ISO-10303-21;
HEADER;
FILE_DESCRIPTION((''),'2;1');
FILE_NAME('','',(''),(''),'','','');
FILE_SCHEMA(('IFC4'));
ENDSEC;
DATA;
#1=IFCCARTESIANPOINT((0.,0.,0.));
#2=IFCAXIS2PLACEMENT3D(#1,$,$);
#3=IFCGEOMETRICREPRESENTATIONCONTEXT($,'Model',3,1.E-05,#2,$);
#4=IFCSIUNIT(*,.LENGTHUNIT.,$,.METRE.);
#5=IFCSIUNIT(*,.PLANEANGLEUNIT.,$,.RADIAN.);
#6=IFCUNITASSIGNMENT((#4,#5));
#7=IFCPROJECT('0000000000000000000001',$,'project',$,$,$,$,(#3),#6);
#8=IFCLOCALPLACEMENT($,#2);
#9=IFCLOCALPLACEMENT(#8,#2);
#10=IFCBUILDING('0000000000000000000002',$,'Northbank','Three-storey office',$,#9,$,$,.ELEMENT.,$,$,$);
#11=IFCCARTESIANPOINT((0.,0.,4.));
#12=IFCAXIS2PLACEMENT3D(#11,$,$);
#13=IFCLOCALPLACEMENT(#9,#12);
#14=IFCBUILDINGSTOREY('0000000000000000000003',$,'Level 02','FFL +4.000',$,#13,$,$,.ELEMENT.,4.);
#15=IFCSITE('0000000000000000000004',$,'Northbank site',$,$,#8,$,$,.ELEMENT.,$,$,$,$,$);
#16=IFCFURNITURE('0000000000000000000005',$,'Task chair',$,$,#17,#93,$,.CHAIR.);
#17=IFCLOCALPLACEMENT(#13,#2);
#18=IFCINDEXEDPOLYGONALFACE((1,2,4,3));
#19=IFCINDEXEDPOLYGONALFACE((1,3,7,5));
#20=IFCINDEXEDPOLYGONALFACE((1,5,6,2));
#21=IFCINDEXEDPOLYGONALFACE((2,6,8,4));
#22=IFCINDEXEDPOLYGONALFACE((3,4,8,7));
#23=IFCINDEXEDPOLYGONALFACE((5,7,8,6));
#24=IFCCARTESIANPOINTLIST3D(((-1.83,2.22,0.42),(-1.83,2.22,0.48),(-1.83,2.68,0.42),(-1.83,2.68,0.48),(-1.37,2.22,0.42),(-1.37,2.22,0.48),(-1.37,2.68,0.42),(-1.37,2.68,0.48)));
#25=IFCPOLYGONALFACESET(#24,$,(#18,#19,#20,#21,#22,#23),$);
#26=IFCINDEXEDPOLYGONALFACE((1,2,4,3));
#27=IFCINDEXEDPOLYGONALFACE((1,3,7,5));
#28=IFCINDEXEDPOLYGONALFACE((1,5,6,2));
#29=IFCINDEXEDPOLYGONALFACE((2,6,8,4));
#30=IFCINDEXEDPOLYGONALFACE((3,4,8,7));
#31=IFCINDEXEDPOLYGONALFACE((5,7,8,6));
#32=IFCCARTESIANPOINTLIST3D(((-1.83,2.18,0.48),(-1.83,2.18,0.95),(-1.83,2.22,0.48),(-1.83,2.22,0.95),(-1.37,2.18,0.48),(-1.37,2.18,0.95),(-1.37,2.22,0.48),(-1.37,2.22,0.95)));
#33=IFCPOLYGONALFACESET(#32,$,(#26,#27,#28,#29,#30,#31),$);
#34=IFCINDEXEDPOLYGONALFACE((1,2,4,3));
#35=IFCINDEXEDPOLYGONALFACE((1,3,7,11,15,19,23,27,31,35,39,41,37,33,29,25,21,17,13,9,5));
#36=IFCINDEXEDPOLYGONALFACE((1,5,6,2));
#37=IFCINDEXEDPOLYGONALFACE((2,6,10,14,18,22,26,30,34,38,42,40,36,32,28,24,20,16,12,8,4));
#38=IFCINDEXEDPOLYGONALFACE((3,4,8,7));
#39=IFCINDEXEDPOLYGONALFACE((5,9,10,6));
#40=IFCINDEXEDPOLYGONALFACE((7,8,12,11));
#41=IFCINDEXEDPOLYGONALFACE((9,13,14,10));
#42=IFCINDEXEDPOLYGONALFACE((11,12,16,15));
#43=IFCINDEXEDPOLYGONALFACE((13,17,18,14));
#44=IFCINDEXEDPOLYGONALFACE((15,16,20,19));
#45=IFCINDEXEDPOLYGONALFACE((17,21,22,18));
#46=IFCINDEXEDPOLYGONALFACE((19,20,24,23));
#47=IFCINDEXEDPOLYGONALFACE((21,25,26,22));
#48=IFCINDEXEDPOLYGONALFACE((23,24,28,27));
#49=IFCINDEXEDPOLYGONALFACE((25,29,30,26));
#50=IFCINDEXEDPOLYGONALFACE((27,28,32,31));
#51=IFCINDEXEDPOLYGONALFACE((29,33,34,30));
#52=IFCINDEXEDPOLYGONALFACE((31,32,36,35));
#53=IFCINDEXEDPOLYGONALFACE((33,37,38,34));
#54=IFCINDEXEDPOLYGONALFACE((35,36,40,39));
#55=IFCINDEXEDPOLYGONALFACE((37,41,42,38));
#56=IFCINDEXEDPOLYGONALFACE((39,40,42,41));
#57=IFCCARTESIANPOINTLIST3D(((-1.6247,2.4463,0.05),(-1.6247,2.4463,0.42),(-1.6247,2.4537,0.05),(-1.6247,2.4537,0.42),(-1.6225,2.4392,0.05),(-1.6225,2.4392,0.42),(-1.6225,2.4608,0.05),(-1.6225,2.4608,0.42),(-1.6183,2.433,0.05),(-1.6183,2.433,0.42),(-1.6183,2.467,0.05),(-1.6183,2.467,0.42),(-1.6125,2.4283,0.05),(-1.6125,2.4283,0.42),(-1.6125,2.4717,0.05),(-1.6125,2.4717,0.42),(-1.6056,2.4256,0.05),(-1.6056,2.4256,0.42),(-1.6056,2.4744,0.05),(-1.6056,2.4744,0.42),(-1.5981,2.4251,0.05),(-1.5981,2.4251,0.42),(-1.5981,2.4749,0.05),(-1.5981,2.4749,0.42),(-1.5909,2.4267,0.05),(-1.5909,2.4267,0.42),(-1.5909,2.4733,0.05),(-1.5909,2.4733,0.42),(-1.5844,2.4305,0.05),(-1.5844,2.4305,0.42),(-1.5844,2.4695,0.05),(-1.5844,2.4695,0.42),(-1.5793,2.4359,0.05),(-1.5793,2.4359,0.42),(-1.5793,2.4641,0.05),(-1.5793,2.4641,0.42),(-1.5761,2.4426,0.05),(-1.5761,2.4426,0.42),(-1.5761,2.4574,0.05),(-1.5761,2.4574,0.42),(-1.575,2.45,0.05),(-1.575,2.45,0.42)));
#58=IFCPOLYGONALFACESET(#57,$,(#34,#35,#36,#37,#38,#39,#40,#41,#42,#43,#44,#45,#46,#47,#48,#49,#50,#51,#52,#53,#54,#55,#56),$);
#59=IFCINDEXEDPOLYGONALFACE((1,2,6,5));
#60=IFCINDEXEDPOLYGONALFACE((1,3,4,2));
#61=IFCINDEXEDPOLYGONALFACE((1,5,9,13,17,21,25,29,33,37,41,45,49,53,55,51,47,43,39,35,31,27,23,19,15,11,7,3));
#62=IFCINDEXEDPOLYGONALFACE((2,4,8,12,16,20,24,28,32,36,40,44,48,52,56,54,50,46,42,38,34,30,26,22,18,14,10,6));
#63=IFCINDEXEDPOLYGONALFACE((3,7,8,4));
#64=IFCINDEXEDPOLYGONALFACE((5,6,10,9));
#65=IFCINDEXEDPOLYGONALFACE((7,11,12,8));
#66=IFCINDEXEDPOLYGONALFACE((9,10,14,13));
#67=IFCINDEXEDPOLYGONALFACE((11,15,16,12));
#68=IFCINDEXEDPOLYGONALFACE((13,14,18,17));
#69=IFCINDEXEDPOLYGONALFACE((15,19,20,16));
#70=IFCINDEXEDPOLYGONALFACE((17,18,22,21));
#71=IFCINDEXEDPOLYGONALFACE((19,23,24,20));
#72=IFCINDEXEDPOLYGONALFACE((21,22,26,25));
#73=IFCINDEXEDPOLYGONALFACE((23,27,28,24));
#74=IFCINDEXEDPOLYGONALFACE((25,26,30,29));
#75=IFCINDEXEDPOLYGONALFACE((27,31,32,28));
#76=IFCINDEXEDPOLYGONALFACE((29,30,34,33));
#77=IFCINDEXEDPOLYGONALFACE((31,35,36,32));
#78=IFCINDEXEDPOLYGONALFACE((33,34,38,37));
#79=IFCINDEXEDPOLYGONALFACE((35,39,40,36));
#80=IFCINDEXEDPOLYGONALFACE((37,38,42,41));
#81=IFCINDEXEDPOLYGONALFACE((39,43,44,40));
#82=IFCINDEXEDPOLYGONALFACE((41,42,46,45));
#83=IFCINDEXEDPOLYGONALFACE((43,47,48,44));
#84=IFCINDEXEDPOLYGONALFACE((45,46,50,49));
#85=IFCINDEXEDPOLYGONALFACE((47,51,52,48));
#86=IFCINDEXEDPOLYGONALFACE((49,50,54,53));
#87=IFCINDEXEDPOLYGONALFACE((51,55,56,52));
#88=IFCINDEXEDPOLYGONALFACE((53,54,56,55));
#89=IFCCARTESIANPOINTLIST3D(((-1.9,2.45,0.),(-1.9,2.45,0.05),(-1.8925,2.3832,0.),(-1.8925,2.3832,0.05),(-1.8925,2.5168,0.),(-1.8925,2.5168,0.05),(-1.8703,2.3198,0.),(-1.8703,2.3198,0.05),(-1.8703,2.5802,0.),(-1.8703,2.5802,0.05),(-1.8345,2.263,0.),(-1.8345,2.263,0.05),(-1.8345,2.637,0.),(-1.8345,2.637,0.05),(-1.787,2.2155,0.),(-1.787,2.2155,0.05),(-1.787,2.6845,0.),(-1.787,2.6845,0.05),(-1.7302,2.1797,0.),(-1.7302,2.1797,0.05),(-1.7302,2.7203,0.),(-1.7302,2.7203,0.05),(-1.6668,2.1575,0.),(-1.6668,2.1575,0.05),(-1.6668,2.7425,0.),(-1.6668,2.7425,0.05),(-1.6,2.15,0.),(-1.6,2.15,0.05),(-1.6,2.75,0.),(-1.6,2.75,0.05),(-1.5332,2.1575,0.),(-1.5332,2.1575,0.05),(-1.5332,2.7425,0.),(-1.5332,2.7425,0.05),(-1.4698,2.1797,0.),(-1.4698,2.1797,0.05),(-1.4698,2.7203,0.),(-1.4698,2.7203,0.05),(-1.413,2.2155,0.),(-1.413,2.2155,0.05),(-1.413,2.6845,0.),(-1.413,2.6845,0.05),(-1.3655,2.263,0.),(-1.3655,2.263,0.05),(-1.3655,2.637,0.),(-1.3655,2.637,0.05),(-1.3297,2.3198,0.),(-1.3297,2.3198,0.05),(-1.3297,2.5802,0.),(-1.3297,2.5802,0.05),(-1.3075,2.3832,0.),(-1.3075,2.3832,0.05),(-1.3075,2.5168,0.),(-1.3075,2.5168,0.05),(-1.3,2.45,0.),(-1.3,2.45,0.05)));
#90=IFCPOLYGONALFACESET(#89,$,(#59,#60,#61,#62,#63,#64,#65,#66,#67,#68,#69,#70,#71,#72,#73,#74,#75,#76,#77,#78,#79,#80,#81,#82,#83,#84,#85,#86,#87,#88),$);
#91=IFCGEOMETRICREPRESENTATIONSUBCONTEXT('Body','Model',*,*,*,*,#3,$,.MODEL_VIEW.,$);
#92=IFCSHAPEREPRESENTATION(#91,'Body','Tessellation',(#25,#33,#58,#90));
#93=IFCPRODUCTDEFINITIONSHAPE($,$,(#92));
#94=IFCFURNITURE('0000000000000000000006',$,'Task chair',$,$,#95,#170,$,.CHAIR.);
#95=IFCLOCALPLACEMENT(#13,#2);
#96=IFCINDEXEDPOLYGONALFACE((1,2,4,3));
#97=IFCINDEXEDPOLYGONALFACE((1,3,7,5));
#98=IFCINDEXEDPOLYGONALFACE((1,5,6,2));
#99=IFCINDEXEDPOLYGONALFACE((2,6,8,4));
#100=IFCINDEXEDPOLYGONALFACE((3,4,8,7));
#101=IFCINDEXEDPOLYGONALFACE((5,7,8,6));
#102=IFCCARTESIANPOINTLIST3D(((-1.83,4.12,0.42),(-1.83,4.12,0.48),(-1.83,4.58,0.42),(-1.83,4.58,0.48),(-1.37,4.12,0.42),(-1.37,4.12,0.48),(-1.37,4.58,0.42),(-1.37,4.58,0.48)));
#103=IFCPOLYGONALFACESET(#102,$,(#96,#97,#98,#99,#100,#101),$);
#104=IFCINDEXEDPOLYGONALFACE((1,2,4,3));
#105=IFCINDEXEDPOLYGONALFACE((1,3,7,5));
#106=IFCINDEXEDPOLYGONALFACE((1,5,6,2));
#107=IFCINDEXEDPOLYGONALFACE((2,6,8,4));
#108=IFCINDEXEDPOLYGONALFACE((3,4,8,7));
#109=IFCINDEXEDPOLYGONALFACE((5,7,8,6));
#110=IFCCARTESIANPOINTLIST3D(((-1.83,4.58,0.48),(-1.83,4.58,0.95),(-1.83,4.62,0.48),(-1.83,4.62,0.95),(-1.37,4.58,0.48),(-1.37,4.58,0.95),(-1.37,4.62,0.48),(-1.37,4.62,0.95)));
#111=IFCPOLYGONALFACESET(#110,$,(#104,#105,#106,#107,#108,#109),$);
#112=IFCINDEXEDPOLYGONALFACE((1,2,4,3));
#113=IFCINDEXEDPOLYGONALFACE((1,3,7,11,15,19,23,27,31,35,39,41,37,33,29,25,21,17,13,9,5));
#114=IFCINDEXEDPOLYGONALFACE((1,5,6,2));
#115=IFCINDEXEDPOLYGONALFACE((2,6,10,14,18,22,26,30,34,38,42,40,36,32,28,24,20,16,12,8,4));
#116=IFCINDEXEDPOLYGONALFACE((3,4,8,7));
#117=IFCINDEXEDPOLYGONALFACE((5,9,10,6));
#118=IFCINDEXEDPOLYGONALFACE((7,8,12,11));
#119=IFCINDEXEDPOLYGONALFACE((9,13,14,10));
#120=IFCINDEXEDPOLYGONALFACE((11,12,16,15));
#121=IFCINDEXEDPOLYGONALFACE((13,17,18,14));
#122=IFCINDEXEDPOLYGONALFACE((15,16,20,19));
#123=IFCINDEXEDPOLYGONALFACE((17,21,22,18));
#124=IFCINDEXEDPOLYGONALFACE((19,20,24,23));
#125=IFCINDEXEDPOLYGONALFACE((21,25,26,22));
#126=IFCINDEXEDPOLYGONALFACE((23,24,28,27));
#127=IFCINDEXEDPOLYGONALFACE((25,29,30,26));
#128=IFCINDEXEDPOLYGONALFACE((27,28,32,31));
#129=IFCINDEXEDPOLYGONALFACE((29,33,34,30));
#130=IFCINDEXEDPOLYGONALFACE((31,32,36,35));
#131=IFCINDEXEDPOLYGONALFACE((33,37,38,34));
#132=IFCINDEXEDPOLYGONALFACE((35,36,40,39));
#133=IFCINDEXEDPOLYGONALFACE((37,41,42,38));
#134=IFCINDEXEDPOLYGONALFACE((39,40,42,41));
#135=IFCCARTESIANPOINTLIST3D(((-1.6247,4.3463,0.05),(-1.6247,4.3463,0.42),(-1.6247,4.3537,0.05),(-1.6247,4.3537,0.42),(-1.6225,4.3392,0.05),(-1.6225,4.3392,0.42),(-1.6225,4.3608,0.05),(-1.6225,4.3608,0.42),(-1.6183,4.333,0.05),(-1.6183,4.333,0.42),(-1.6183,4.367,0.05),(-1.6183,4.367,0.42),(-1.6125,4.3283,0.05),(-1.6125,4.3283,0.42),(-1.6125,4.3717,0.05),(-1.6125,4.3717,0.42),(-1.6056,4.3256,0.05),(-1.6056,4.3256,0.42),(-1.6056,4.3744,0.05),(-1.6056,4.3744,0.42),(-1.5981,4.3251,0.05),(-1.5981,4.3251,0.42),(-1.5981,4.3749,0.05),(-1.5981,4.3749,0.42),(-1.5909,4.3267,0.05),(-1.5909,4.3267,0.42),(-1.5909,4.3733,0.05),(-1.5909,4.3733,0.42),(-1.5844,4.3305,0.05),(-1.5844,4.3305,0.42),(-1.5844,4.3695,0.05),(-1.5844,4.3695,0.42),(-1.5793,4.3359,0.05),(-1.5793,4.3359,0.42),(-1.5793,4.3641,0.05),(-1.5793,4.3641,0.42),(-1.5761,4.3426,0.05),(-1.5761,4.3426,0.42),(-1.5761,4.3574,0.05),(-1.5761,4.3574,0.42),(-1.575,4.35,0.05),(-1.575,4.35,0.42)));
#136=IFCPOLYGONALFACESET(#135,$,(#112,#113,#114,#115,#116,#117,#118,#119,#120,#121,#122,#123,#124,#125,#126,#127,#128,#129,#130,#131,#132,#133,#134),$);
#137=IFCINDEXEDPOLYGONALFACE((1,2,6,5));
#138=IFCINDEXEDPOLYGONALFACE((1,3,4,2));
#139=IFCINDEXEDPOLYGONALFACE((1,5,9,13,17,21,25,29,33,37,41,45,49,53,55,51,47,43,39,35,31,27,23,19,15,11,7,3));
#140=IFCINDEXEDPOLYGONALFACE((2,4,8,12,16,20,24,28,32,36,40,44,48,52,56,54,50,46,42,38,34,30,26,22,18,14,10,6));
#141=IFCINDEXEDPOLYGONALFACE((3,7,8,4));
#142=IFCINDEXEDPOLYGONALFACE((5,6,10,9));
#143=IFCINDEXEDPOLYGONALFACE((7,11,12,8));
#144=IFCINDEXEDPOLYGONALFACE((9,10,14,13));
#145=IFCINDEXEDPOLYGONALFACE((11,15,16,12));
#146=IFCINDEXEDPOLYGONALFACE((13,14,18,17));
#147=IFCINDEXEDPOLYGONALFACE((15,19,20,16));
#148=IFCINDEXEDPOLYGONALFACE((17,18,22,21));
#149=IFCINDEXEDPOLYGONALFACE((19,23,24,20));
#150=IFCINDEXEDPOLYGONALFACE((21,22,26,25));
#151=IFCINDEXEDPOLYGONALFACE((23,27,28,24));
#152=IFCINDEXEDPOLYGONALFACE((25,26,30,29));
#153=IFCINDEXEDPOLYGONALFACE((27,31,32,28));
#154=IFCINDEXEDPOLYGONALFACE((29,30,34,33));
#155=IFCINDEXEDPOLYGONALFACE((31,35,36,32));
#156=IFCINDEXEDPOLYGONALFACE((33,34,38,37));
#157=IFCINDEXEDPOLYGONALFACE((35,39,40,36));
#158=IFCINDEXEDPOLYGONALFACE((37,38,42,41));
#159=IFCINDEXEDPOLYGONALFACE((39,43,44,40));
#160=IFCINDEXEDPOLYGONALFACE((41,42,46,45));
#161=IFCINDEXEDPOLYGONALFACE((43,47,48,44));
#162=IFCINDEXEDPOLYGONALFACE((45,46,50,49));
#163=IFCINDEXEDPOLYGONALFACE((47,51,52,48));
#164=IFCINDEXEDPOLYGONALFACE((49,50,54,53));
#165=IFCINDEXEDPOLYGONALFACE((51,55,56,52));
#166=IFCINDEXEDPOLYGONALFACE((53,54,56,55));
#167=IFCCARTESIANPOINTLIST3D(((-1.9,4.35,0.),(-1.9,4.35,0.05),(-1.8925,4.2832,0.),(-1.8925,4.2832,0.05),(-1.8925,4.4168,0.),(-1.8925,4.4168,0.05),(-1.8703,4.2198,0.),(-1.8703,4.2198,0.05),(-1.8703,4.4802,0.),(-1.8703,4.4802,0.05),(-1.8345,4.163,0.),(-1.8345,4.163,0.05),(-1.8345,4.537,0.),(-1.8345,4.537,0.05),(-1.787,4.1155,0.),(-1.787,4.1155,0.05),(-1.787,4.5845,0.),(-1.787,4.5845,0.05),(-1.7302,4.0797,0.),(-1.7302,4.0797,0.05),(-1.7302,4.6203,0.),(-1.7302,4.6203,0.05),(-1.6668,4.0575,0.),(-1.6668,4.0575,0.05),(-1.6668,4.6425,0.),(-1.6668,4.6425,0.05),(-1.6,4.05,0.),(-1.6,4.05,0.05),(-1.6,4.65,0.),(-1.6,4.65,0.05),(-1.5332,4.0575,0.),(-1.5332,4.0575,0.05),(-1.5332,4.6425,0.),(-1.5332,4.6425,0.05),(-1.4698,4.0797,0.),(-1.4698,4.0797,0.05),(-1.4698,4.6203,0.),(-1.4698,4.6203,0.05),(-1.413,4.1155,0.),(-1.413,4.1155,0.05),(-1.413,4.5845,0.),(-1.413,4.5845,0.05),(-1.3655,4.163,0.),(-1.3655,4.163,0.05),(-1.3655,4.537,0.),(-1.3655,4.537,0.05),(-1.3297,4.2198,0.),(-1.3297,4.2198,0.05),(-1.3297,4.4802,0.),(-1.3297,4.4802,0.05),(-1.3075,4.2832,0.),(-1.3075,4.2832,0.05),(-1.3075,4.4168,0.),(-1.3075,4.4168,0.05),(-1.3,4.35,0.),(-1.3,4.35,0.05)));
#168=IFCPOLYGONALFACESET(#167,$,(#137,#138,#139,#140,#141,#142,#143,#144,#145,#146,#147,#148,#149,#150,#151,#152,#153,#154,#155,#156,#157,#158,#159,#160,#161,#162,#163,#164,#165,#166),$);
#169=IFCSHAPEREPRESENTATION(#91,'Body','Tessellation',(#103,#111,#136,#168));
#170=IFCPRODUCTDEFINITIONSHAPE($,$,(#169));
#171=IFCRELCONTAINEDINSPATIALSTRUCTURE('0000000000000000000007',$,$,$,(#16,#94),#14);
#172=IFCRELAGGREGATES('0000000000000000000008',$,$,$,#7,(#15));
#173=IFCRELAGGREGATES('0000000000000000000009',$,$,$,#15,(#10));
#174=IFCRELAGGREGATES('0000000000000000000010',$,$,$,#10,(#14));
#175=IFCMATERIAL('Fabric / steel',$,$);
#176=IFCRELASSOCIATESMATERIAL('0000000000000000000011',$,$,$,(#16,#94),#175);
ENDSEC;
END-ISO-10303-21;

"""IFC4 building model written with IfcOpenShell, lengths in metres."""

from ifc_helpers import new_model, si_unit, frame, origin, place, context, subcontext, project, spatial, rectangle, circle, extrude, material, element, save


model = new_model("IFC4")

# Units and contexts
model_context = context("Model", 3, precision=1e-05, world=origin())
body_context = subcontext(model_context, "Body", "Model", "MODEL_VIEW")
ifc_project = project(units=[si_unit("LENGTHUNIT", "METRE"), si_unit("PLANEANGLEUNIT", "RADIAN")], contexts=[model_context])

# Site, building, storey
site_placement = place(None, origin())
site = spatial("IfcSite", under=ifc_project, at=site_placement, Name="Northbank site", CompositionType="ELEMENT")
building_placement = place(site_placement, origin())
building = spatial("IfcBuilding", under=site, at=building_placement, Name="Northbank", Description="Three-storey office", CompositionType="ELEMENT")
storey_placement = place(building_placement, frame((0.0, 0.0, 4.0)))
storey = spatial("IfcBuildingStorey", under=building, at=storey_placement, Name="Level 02", Description="FFL +4.000", CompositionType="ELEMENT", Elevation=4.0)

# Furniture
ifc_material_1 = material(Name="Fabric / steel")
furniture_1_placement = place(storey_placement, frame((0.0, 0.0, -4.0)))
element("IfcFurniture", 1, at=furniture_1_placement, inside=storey, material=ifc_material_1, Name="Task chair", PredefinedType="CHAIR", context=body_context, shape_type="SweptSolid", body=[
    extrude(rectangle(XDim=0.46, YDim=0.46), frame((-1.6, 2.45, 4.42)), (0.0, 0.0, 1.0), 0.06),
    extrude(rectangle(XDim=0.46, YDim=0.04), frame((-1.6, 2.2, 4.48)), (0.0, 0.0, 1.0), 0.47),
    extrude(circle(Radius=0.025), frame((-1.6, 2.45, 4.05), z_axis=(0.0, 0.0, 1.0), x_axis=(1.0, 0.0, 0.0)), (0.0, 0.0, 1.0), 0.37),
    extrude(circle(Radius=0.3), frame((-1.6, 2.45, 4.0), z_axis=(0.0, 0.0, 1.0), x_axis=(1.0, 0.0, 0.0)), (0.0, 0.0, 1.0), 0.05),
])
furniture_2_placement = place(storey_placement, frame((0.0, 0.0, -4.0)))
element("IfcFurniture", 2, at=furniture_2_placement, inside=storey, material=ifc_material_1, Name="Task chair", PredefinedType="CHAIR", context=body_context, shape_type="SweptSolid", body=[
    extrude(rectangle(XDim=0.46, YDim=0.46), frame((-1.6, 4.35, 4.42)), (0.0, 0.0, 1.0), 0.06),
    extrude(rectangle(XDim=0.46, YDim=0.04), frame((-1.6, 4.6, 4.48)), (0.0, 0.0, 1.0), 0.47),
    extrude(circle(Radius=0.025), frame((-1.6, 4.35, 4.05), z_axis=(0.0, 0.0, 1.0), x_axis=(1.0, 0.0, 0.0)), (0.0, 0.0, 1.0), 0.37),
    extrude(circle(Radius=0.3), frame((-1.6, 4.35, 4.0), z_axis=(0.0, 0.0, 1.0), x_axis=(1.0, 0.0, 0.0)), (0.0, 0.0, 1.0), 0.05),
])

save(model, "model.ifc")
